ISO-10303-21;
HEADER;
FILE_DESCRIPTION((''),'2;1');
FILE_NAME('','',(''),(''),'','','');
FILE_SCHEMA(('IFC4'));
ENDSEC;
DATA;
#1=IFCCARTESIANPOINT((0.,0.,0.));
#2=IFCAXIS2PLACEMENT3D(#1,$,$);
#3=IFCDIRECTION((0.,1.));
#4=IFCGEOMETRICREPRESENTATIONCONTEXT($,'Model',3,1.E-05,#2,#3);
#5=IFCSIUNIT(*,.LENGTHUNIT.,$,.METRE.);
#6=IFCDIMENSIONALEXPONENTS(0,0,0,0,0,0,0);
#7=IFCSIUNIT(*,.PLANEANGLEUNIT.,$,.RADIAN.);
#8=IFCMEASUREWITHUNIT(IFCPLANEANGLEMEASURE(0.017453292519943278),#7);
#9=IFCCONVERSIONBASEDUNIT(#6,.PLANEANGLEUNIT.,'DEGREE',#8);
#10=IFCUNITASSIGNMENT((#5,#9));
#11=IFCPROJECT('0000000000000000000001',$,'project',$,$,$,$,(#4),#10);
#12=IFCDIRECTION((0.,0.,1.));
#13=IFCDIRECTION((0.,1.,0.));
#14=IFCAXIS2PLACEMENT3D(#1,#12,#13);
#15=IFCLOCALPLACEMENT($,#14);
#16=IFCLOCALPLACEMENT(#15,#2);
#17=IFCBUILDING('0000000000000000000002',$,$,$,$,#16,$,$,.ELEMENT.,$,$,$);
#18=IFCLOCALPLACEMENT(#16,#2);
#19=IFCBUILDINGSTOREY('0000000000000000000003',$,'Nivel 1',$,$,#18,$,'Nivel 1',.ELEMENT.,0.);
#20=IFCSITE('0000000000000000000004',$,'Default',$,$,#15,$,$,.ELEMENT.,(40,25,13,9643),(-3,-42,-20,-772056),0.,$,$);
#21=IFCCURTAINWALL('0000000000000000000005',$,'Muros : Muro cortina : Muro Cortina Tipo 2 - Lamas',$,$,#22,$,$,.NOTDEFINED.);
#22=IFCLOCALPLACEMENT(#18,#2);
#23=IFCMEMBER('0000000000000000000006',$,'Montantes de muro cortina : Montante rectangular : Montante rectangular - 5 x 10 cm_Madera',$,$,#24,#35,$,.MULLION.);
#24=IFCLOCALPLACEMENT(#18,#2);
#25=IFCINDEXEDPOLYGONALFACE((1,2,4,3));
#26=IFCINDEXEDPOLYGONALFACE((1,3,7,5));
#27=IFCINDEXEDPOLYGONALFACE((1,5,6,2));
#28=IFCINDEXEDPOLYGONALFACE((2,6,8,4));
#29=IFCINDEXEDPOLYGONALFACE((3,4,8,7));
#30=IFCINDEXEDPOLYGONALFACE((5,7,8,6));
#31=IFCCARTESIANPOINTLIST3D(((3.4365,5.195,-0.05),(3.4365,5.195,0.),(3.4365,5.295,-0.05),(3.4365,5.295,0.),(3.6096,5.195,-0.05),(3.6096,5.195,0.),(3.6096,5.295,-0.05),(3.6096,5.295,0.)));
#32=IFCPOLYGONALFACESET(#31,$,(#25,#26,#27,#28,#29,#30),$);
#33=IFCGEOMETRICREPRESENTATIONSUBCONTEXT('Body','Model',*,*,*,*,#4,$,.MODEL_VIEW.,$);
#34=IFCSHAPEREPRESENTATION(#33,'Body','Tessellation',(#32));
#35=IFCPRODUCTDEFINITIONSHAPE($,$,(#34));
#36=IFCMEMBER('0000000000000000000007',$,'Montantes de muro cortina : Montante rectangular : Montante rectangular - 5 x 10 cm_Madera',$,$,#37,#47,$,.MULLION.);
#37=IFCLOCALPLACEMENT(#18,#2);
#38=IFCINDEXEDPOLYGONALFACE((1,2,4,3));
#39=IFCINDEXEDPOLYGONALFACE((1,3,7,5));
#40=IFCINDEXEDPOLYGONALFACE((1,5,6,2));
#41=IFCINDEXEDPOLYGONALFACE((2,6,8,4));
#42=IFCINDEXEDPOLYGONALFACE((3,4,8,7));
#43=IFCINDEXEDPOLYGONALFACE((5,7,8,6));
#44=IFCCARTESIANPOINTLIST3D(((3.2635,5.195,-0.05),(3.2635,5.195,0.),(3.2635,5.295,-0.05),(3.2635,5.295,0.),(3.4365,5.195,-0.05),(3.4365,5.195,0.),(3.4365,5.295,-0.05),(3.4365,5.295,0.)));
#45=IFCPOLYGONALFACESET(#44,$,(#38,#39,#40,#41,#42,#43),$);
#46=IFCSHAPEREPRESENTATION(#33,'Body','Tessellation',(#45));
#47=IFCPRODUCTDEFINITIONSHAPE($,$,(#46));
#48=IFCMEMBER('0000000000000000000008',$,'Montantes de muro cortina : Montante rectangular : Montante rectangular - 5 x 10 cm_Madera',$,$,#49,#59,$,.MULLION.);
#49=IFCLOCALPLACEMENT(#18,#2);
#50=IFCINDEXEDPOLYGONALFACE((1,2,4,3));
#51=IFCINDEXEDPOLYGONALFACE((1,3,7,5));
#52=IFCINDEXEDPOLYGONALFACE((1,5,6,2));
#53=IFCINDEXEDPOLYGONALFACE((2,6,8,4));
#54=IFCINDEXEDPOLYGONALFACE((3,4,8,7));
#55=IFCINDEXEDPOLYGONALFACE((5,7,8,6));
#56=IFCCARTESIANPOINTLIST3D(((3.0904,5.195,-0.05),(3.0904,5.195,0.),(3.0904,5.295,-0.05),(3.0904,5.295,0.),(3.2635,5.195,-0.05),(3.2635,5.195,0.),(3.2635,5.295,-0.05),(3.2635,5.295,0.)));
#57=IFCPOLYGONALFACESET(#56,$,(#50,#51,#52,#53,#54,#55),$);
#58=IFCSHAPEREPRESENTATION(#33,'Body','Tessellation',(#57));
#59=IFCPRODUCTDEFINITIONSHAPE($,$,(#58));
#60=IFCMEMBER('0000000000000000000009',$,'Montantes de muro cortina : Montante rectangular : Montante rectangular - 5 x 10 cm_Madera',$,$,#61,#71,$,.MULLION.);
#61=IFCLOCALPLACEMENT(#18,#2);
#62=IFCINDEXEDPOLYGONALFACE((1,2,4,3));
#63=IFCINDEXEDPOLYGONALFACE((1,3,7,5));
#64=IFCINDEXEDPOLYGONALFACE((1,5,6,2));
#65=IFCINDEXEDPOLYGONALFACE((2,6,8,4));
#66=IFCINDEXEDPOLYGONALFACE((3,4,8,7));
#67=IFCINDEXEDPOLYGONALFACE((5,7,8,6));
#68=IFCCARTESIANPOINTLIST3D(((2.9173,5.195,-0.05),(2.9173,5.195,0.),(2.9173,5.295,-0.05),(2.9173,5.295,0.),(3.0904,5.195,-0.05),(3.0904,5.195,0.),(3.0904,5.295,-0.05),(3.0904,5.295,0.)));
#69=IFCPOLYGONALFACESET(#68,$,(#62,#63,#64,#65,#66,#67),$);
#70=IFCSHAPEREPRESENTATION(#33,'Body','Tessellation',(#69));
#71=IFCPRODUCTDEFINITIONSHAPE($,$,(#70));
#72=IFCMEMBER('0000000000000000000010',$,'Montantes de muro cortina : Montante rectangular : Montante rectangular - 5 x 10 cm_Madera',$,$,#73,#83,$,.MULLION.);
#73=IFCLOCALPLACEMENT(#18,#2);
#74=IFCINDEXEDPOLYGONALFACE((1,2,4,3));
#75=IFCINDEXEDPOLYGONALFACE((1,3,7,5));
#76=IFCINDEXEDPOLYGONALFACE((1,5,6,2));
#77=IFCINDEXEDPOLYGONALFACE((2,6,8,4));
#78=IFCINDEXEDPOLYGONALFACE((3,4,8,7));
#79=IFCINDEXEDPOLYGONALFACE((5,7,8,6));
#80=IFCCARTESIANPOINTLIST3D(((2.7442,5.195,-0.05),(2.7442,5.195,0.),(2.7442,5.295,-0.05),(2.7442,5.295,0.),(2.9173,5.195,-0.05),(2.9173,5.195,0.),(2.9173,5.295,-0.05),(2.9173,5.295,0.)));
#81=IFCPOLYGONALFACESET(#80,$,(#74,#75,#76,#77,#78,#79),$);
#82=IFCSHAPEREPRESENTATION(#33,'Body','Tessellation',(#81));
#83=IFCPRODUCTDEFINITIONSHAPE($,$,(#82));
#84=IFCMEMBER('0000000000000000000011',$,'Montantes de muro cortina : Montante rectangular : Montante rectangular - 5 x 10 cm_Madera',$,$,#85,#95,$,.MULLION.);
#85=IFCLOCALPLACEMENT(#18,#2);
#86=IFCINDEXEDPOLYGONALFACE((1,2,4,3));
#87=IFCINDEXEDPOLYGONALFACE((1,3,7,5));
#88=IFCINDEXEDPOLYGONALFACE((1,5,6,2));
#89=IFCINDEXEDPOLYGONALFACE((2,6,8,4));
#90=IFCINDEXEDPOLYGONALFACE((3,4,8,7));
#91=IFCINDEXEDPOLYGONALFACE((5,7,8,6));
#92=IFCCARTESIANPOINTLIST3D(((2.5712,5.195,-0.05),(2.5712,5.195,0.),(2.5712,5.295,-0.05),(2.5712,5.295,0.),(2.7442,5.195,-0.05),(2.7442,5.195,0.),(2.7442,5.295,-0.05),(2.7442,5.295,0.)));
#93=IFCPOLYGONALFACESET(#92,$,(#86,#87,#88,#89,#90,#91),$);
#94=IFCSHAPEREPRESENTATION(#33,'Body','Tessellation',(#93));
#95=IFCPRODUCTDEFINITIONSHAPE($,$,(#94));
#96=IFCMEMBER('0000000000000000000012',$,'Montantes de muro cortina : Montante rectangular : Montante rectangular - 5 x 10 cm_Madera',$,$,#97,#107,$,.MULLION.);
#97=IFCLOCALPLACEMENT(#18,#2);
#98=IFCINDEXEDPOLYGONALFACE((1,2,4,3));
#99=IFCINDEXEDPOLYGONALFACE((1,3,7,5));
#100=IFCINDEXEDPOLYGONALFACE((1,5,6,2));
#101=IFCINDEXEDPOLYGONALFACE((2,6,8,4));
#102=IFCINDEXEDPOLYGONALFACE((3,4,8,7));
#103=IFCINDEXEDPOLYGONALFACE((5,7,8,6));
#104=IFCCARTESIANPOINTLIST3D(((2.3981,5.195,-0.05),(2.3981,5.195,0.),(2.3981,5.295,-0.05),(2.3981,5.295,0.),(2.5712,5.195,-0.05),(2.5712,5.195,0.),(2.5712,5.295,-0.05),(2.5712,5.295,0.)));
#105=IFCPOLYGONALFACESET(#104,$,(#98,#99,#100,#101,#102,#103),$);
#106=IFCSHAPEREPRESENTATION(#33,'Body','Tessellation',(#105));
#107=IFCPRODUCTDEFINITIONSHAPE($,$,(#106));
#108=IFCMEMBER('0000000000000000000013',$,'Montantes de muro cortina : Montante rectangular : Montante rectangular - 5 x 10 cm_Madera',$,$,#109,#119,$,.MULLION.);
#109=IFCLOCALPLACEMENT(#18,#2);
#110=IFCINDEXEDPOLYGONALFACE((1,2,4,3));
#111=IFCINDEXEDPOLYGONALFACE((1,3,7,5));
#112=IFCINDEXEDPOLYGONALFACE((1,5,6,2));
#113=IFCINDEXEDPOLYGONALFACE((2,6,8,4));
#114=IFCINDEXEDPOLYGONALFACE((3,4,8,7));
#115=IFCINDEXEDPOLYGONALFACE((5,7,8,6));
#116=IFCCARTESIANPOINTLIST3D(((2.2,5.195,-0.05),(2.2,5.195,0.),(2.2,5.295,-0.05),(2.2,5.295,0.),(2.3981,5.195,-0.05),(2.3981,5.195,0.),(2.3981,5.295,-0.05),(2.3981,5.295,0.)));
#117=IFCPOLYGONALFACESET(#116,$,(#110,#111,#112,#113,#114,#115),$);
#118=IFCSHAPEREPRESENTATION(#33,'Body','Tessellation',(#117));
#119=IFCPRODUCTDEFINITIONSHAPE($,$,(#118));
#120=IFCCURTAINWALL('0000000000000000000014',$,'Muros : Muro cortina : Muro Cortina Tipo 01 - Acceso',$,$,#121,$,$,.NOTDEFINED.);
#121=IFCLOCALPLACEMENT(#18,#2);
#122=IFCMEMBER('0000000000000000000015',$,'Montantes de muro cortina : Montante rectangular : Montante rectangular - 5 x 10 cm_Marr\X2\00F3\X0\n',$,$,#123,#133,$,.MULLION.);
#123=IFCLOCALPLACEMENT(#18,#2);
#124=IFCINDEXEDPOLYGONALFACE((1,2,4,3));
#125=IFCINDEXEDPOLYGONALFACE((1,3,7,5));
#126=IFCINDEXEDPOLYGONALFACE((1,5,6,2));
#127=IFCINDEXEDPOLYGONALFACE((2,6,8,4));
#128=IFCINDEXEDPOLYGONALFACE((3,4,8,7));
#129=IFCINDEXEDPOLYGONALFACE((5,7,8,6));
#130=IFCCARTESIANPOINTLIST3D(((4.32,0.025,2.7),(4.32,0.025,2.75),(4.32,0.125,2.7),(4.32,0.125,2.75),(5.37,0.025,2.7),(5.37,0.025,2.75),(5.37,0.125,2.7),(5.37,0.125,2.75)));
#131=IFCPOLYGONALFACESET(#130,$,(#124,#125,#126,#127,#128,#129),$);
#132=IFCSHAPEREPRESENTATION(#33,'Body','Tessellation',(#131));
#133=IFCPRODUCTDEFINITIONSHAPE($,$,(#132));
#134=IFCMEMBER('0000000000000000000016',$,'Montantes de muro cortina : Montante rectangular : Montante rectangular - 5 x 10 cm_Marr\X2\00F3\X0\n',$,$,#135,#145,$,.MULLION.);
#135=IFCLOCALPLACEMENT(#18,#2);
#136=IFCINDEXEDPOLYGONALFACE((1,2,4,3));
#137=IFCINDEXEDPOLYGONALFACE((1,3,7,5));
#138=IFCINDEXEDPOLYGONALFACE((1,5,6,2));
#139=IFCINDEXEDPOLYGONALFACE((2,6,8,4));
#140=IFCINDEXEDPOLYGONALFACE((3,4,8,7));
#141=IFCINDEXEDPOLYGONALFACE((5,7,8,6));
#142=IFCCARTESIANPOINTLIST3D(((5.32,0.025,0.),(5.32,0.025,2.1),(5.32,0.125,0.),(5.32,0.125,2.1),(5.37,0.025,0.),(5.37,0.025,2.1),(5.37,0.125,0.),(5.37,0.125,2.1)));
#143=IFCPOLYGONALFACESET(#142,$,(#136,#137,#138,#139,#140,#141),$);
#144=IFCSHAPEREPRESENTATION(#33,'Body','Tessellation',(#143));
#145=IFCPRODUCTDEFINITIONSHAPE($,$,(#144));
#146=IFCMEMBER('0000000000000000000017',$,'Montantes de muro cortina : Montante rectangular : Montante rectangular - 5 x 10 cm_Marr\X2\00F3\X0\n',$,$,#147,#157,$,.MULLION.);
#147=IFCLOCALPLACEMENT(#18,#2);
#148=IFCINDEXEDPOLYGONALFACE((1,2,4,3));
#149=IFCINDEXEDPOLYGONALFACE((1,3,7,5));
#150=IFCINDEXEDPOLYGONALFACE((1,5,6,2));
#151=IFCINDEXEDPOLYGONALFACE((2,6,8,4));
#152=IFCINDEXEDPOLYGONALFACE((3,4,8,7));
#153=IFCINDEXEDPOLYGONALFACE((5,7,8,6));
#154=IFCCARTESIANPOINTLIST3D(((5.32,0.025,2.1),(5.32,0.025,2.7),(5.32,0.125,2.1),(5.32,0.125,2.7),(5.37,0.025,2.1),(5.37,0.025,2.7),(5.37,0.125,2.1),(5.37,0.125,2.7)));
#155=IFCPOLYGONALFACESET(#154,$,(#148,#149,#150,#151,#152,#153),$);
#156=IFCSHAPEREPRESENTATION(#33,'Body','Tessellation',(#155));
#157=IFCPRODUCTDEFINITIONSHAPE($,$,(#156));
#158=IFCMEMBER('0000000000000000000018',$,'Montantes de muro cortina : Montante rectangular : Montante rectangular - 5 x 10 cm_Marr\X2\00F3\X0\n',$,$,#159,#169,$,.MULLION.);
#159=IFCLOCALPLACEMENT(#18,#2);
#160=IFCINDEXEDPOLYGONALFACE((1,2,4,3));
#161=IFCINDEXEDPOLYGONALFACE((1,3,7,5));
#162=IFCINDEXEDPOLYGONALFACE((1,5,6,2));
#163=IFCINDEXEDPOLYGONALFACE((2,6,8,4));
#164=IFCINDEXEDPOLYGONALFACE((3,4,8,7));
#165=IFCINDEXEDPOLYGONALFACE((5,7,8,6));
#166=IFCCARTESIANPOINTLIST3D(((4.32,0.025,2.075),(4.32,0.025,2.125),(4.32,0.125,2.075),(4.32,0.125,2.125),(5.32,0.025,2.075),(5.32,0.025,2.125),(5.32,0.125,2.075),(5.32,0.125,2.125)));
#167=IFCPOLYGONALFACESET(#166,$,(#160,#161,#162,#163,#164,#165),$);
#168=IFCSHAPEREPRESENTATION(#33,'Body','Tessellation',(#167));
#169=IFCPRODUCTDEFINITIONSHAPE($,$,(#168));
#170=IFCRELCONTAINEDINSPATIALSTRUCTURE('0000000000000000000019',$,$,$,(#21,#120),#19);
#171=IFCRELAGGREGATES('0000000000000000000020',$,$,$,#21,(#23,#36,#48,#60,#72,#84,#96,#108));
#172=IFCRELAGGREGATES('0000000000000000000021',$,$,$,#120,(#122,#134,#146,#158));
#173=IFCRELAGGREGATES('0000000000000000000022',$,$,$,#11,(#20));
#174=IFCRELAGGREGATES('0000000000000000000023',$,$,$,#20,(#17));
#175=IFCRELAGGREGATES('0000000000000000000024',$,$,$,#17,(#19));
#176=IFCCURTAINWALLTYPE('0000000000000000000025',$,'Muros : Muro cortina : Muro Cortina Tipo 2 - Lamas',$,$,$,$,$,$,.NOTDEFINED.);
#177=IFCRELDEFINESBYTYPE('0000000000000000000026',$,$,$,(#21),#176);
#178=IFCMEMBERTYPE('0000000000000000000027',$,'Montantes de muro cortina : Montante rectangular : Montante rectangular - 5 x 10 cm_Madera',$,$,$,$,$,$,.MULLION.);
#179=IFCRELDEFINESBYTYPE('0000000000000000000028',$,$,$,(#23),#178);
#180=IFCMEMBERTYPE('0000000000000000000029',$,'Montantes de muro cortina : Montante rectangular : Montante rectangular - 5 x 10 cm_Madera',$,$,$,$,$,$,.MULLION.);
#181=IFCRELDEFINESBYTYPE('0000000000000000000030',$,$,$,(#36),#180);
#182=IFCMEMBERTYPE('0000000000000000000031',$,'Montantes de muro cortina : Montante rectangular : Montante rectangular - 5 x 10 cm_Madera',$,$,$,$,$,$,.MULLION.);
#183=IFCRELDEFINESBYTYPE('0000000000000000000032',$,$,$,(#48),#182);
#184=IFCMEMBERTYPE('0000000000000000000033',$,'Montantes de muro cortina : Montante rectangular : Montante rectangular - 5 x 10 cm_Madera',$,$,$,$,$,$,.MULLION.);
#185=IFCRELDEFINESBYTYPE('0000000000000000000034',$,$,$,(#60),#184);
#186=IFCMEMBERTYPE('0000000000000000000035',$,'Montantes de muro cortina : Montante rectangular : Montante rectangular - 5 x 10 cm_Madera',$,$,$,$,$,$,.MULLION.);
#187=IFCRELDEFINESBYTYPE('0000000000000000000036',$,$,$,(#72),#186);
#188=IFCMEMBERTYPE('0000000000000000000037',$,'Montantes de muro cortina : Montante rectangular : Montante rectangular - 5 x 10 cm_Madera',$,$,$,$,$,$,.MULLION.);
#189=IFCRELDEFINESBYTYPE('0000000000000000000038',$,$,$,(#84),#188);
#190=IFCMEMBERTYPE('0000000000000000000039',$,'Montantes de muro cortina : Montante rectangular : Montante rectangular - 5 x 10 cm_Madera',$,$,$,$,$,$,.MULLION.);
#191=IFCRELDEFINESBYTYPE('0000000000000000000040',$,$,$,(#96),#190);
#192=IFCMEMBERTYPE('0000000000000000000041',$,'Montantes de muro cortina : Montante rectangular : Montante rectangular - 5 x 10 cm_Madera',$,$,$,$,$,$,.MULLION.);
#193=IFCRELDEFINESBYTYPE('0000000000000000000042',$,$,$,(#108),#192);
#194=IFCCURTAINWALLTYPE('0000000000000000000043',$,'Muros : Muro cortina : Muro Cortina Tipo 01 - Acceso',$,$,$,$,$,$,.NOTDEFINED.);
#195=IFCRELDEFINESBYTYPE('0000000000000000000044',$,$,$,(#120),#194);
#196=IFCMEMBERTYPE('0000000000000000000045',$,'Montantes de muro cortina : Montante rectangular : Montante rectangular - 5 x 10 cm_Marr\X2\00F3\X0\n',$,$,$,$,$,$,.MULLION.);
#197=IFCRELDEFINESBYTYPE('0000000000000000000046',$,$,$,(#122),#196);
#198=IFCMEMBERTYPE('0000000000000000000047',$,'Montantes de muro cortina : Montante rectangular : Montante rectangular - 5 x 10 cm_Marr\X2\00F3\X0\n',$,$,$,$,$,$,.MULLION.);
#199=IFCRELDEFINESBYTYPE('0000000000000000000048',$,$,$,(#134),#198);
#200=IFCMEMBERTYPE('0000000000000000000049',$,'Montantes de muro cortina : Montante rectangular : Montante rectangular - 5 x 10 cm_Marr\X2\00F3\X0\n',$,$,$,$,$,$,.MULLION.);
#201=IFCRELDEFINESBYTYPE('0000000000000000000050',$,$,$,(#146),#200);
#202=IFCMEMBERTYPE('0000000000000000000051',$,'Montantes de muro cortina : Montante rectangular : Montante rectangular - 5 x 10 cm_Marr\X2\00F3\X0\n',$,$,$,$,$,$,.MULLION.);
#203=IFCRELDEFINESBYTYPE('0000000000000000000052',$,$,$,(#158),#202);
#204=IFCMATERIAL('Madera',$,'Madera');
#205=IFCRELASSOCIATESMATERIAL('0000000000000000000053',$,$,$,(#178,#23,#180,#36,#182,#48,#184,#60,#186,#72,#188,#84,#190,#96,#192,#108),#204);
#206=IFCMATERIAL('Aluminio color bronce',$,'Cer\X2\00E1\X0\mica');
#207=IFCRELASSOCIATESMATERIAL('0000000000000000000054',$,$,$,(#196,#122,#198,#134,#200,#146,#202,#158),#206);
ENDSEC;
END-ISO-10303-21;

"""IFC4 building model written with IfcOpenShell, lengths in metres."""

from ifc_helpers import new_model, entity, si_unit, converted_unit, direction, frame, origin, place, context, subcontext, project, spatial, indexed_curve, outline, extrude, source, transform, mapped, material, type_object, type_shapes, element, aggregate, save


model = new_model("IFC4")

# Units and contexts
model_context = context("Model", 3, precision=1e-05, world=origin(), true_north=direction((0.0, 1.0)))
body_context = subcontext(model_context, "Body", "Model", "MODEL_VIEW")
ifc_project = project(units=[si_unit("LENGTHUNIT", "METRE"), converted_unit("PLANEANGLEUNIT", "DEGREE", entity("IfcPlaneAngleMeasure", 0.017453292519943278), si_unit("PLANEANGLEUNIT", "RADIAN"), dimensions=[0, 0, 0, 0, 0, 0, 0])], contexts=[model_context])

# Site, building, storey
site_placement = place(None, frame((0.0, 0.0, 0.0), z_axis=(0.0, 0.0, 1.0), x_axis=(0.0, 1.0, 0.0)))
site = spatial("IfcSite", under=ifc_project, at=site_placement, Name="Default", CompositionType="ELEMENT", RefLatitude=(40, 25, 13, 9643), RefLongitude=(-3, -42, -20, -772056), RefElevation=0.0)
building_placement = place(site_placement, origin())
building = spatial("IfcBuilding", under=site, at=building_placement, CompositionType="ELEMENT")
storey_placement = place(building_placement, origin())
storey = spatial("IfcBuildingStorey", under=building, at=storey_placement, Name="Nivel 1", LongName="Nivel 1", CompositionType="ELEMENT", Elevation=0.0)

# Curtain wall, members
curtain_wall_type_1 = type_object("IfcCurtainWallType", Name="Muros : Muro cortina : Muro Cortina Tipo 2 - Lamas", PredefinedType="NOTDEFINED")
curtain_wall_1_placement = place(storey_placement, origin())
curtain_wall_1 = element("IfcCurtainWall", 1, at=curtain_wall_1_placement, inside=storey, type_object=curtain_wall_type_1, Name="Muros : Muro cortina : Muro Cortina Tipo 2 - Lamas", PredefinedType="NOTDEFINED")
ifc_material_1 = material(Name="Madera", Category="Madera")
member_type_1 = type_object("IfcMemberType", Name="Montantes de muro cortina : Montante rectangular : Montante rectangular - 5 x 10 cm_Madera", PredefinedType="MULLION", material=ifc_material_1)
shared_shape_1 = source(origin(), body_context, "Body", "SweptSolid", [
    extrude(outline(indexed_curve([(-0.0865, -0.05), (0.0865, -0.05), (0.0865, 0.05), (-0.0865, 0.05), (-0.0865, -0.05)], self_intersect=False)), frame((3.5231, 5.245, -0.05)), (0.0, 0.0, 1.0), 0.05),
])
type_shapes(member_type_1, [shared_shape_1])
member_1_placement = place(curtain_wall_1_placement, origin())
member_1 = element("IfcMember", 2, at=member_1_placement, type_object=member_type_1, material=ifc_material_1, Name="Montantes de muro cortina : Montante rectangular : Montante rectangular - 5 x 10 cm_Madera", PredefinedType="MULLION", context=body_context, shape_type="MappedRepresentation", body=[
    mapped(shared_shape_1, transform((0.0, 0.0, 0.0), scale=1.0)),
])
member_type_2 = type_object("IfcMemberType", Name="Montantes de muro cortina : Montante rectangular : Montante rectangular - 5 x 10 cm_Madera", PredefinedType="MULLION", material=ifc_material_1)
shared_shape_2 = source(origin(), body_context, "Body", "SweptSolid", [
    extrude(outline(indexed_curve([(-0.0865, -0.05), (0.0865, -0.05), (0.0865, 0.05), (-0.0865, 0.05), (-0.0865, -0.05)], self_intersect=False)), frame((3.35, 5.245, -0.05)), (0.0, 0.0, 1.0), 0.05),
])
type_shapes(member_type_2, [shared_shape_2])
member_2_placement = place(curtain_wall_1_placement, origin())
member_2 = element("IfcMember", 3, at=member_2_placement, type_object=member_type_2, material=ifc_material_1, Name="Montantes de muro cortina : Montante rectangular : Montante rectangular - 5 x 10 cm_Madera", PredefinedType="MULLION", context=body_context, shape_type="MappedRepresentation", body=[
    mapped(shared_shape_2, transform((0.0, 0.0, 0.0), scale=1.0)),
])
member_type_3 = type_object("IfcMemberType", Name="Montantes de muro cortina : Montante rectangular : Montante rectangular - 5 x 10 cm_Madera", PredefinedType="MULLION", material=ifc_material_1)
shared_shape_3 = source(origin(), body_context, "Body", "SweptSolid", [
    extrude(outline(indexed_curve([(-0.0865, -0.05), (0.0865, -0.05), (0.0865, 0.05), (-0.0865, 0.05), (-0.0865, -0.05)], self_intersect=False)), frame((3.1769, 5.245, -0.05)), (0.0, 0.0, 1.0), 0.05),
])
type_shapes(member_type_3, [shared_shape_3])
member_3_placement = place(curtain_wall_1_placement, origin())
member_3 = element("IfcMember", 4, at=member_3_placement, type_object=member_type_3, material=ifc_material_1, Name="Montantes de muro cortina : Montante rectangular : Montante rectangular - 5 x 10 cm_Madera", PredefinedType="MULLION", context=body_context, shape_type="MappedRepresentation", body=[
    mapped(shared_shape_3, transform((0.0, 0.0, 0.0), scale=1.0)),
])
member_type_4 = type_object("IfcMemberType", Name="Montantes de muro cortina : Montante rectangular : Montante rectangular - 5 x 10 cm_Madera", PredefinedType="MULLION", material=ifc_material_1)
shared_shape_4 = source(origin(), body_context, "Body", "SweptSolid", [
    extrude(outline(indexed_curve([(-0.0865, -0.05), (0.0865, -0.05), (0.0865, 0.05), (-0.0865, 0.05), (-0.0865, -0.05)], self_intersect=False)), frame((3.0038, 5.245, -0.05)), (0.0, 0.0, 1.0), 0.05),
])
type_shapes(member_type_4, [shared_shape_4])
member_4_placement = place(curtain_wall_1_placement, origin())
member_4 = element("IfcMember", 5, at=member_4_placement, type_object=member_type_4, material=ifc_material_1, Name="Montantes de muro cortina : Montante rectangular : Montante rectangular - 5 x 10 cm_Madera", PredefinedType="MULLION", context=body_context, shape_type="MappedRepresentation", body=[
    mapped(shared_shape_4, transform((0.0, 0.0, 0.0), scale=1.0)),
])
member_type_5 = type_object("IfcMemberType", Name="Montantes de muro cortina : Montante rectangular : Montante rectangular - 5 x 10 cm_Madera", PredefinedType="MULLION", material=ifc_material_1)
shared_shape_5 = source(origin(), body_context, "Body", "SweptSolid", [
    extrude(outline(indexed_curve([(-0.0865, -0.05), (0.0865, -0.05), (0.0865, 0.05), (-0.0865, 0.05), (-0.0865, -0.05)], self_intersect=False)), frame((2.8308, 5.245, -0.05)), (0.0, 0.0, 1.0), 0.05),
])
type_shapes(member_type_5, [shared_shape_5])
member_5_placement = place(curtain_wall_1_placement, origin())
member_5 = element("IfcMember", 6, at=member_5_placement, type_object=member_type_5, material=ifc_material_1, Name="Montantes de muro cortina : Montante rectangular : Montante rectangular - 5 x 10 cm_Madera", PredefinedType="MULLION", context=body_context, shape_type="MappedRepresentation", body=[
    mapped(shared_shape_5, transform((0.0, 0.0, 0.0), scale=1.0)),
])
member_type_6 = type_object("IfcMemberType", Name="Montantes de muro cortina : Montante rectangular : Montante rectangular - 5 x 10 cm_Madera", PredefinedType="MULLION", material=ifc_material_1)
shared_shape_6 = source(origin(), body_context, "Body", "SweptSolid", [
    extrude(outline(indexed_curve([(-0.0865, -0.05), (0.0865, -0.05), (0.0865, 0.05), (-0.0865, 0.05), (-0.0865, -0.05)], self_intersect=False)), frame((2.6577, 5.245, -0.05)), (0.0, 0.0, 1.0), 0.05),
])
type_shapes(member_type_6, [shared_shape_6])
member_6_placement = place(curtain_wall_1_placement, origin())
member_6 = element("IfcMember", 7, at=member_6_placement, type_object=member_type_6, material=ifc_material_1, Name="Montantes de muro cortina : Montante rectangular : Montante rectangular - 5 x 10 cm_Madera", PredefinedType="MULLION", context=body_context, shape_type="MappedRepresentation", body=[
    mapped(shared_shape_6, transform((0.0, 0.0, 0.0), scale=1.0)),
])
member_type_7 = type_object("IfcMemberType", Name="Montantes de muro cortina : Montante rectangular : Montante rectangular - 5 x 10 cm_Madera", PredefinedType="MULLION", material=ifc_material_1)
shared_shape_7 = source(origin(), body_context, "Body", "SweptSolid", [
    extrude(outline(indexed_curve([(-0.0865, -0.05), (0.0865, -0.05), (0.0865, 0.05), (-0.0865, 0.05), (-0.0865, -0.05)], self_intersect=False)), frame((2.4846, 5.245, -0.05)), (0.0, 0.0, 1.0), 0.05),
])
type_shapes(member_type_7, [shared_shape_7])
member_7_placement = place(curtain_wall_1_placement, origin())
member_7 = element("IfcMember", 8, at=member_7_placement, type_object=member_type_7, material=ifc_material_1, Name="Montantes de muro cortina : Montante rectangular : Montante rectangular - 5 x 10 cm_Madera", PredefinedType="MULLION", context=body_context, shape_type="MappedRepresentation", body=[
    mapped(shared_shape_7, transform((0.0, 0.0, 0.0), scale=1.0)),
])
member_type_8 = type_object("IfcMemberType", Name="Montantes de muro cortina : Montante rectangular : Montante rectangular - 5 x 10 cm_Madera", PredefinedType="MULLION", material=ifc_material_1)
shared_shape_8 = source(origin(), body_context, "Body", "SweptSolid", [
    extrude(outline(indexed_curve([(-0.099, -0.05), (0.099, -0.05), (0.099, 0.05), (-0.099, 0.05), (-0.099, -0.05)], self_intersect=False)), frame((2.299, 5.245, -0.05)), (0.0, 0.0, 1.0), 0.05),
])
type_shapes(member_type_8, [shared_shape_8])
member_8_placement = place(curtain_wall_1_placement, origin())
member_8 = element("IfcMember", 9, at=member_8_placement, type_object=member_type_8, material=ifc_material_1, Name="Montantes de muro cortina : Montante rectangular : Montante rectangular - 5 x 10 cm_Madera", PredefinedType="MULLION", context=body_context, shape_type="MappedRepresentation", body=[
    mapped(shared_shape_8, transform((0.0, 0.0, 0.0), scale=1.0)),
])
aggregate(curtain_wall_1, [member_1, member_2, member_3, member_4, member_5, member_6, member_7, member_8])

# Curtain wall, members
curtain_wall_type_2 = type_object("IfcCurtainWallType", Name="Muros : Muro cortina : Muro Cortina Tipo 01 - Acceso", PredefinedType="NOTDEFINED")
curtain_wall_2_placement = place(storey_placement, origin())
curtain_wall_2 = element("IfcCurtainWall", 10, at=curtain_wall_2_placement, inside=storey, type_object=curtain_wall_type_2, Name="Muros : Muro cortina : Muro Cortina Tipo 01 - Acceso", PredefinedType="NOTDEFINED")
ifc_material_2 = material(Name="Aluminio color bronce", Category="Cerámica")
member_type_9 = type_object("IfcMemberType", Name="Montantes de muro cortina : Montante rectangular : Montante rectangular - 5 x 10 cm_Marrón", PredefinedType="MULLION", material=ifc_material_2)
shared_shape_9 = source(origin(), body_context, "Body", "SweptSolid", [
    extrude(outline(indexed_curve([(-0.05, -0.025), (0.05, -0.025), (0.05, 0.025), (-0.05, 0.025), (-0.05, -0.025)], self_intersect=False)), frame((-0.025, 0.0, -1.05), z_axis=(0.0, 0.0, 1.0), x_axis=(0.0, 1.0, 0.0)), (0.0, 0.0, 1.0), 1.05),
])
type_shapes(member_type_9, [shared_shape_9])
member_9_placement = place(curtain_wall_2_placement, frame((5.37, 0.075, 2.75), z_axis=(1.0, 0.0, 0.0), x_axis=(0.0, 0.0, 1.0)))
member_9 = element("IfcMember", 11, at=member_9_placement, type_object=member_type_9, material=ifc_material_2, Name="Montantes de muro cortina : Montante rectangular : Montante rectangular - 5 x 10 cm_Marrón", PredefinedType="MULLION", context=body_context, shape_type="MappedRepresentation", body=[
    mapped(shared_shape_9, transform((0.0, 0.0, 0.0), scale=1.0)),
])
member_type_10 = type_object("IfcMemberType", Name="Montantes de muro cortina : Montante rectangular : Montante rectangular - 5 x 10 cm_Marrón", PredefinedType="MULLION", material=ifc_material_2)
shared_shape_10 = source(origin(), body_context, "Body", "SweptSolid", [
    extrude(outline(indexed_curve([(-0.05, -0.025), (0.05, -0.025), (0.05, 0.025), (-0.05, 0.025), (-0.05, -0.025)], self_intersect=False)), frame((-0.025, 0.0, -2.1), z_axis=(0.0, 0.0, 1.0), x_axis=(0.0, 1.0, 0.0)), (0.0, 0.0, 1.0), 2.1),
])
type_shapes(member_type_10, [shared_shape_10])
member_10_placement = place(curtain_wall_2_placement, frame((5.37, 0.075, 0.0), z_axis=(0.0, 0.0, -1.0), x_axis=(1.0, 0.0, 0.0)))
member_10 = element("IfcMember", 12, at=member_10_placement, type_object=member_type_10, material=ifc_material_2, Name="Montantes de muro cortina : Montante rectangular : Montante rectangular - 5 x 10 cm_Marrón", PredefinedType="MULLION", context=body_context, shape_type="MappedRepresentation", body=[
    mapped(shared_shape_10, transform((0.0, 0.0, 0.0), scale=1.0)),
])
member_type_11 = type_object("IfcMemberType", Name="Montantes de muro cortina : Montante rectangular : Montante rectangular - 5 x 10 cm_Marrón", PredefinedType="MULLION", material=ifc_material_2)
shared_shape_11 = source(origin(), body_context, "Body", "SweptSolid", [
    extrude(outline(indexed_curve([(-0.05, -0.025), (0.05, -0.025), (0.05, 0.025), (-0.05, 0.025), (-0.05, -0.025)], self_intersect=False)), frame((-0.025, 0.0, -0.6), z_axis=(0.0, 0.0, 1.0), x_axis=(0.0, 1.0, 0.0)), (0.0, 0.0, 1.0), 0.6),
])
type_shapes(member_type_11, [shared_shape_11])
member_11_placement = place(curtain_wall_2_placement, frame((5.37, 0.075, 2.1), z_axis=(0.0, 0.0, -1.0), x_axis=(1.0, 0.0, 0.0)))
member_11 = element("IfcMember", 13, at=member_11_placement, type_object=member_type_11, material=ifc_material_2, Name="Montantes de muro cortina : Montante rectangular : Montante rectangular - 5 x 10 cm_Marrón", PredefinedType="MULLION", context=body_context, shape_type="MappedRepresentation", body=[
    mapped(shared_shape_11, transform((0.0, 0.0, 0.0), scale=1.0)),
])
member_type_12 = type_object("IfcMemberType", Name="Montantes de muro cortina : Montante rectangular : Montante rectangular - 5 x 10 cm_Marrón", PredefinedType="MULLION", material=ifc_material_2)
shared_shape_12 = source(origin(), body_context, "Body", "SweptSolid", [
    extrude(outline(indexed_curve([(-0.05, -0.025), (0.05, -0.025), (0.05, 0.025), (-0.05, 0.025), (-0.05, -0.025)], self_intersect=False)), frame((0.0, 0.0, -1.0), z_axis=(0.0, 0.0, 1.0), x_axis=(0.0, 1.0, 0.0)), (0.0, 0.0, 1.0), 1.0),
])
type_shapes(member_type_12, [shared_shape_12])
member_12_placement = place(curtain_wall_2_placement, frame((5.32, 0.075, 2.1), z_axis=(1.0, 0.0, 0.0), x_axis=(0.0, 0.0, 1.0)))
member_12 = element("IfcMember", 14, at=member_12_placement, type_object=member_type_12, material=ifc_material_2, Name="Montantes de muro cortina : Montante rectangular : Montante rectangular - 5 x 10 cm_Marrón", PredefinedType="MULLION", context=body_context, shape_type="MappedRepresentation", body=[
    mapped(shared_shape_12, transform((0.0, 0.0, 0.0), scale=1.0)),
])
aggregate(curtain_wall_2, [member_9, member_10, member_11, member_12])

save(model, "model.ifc")
